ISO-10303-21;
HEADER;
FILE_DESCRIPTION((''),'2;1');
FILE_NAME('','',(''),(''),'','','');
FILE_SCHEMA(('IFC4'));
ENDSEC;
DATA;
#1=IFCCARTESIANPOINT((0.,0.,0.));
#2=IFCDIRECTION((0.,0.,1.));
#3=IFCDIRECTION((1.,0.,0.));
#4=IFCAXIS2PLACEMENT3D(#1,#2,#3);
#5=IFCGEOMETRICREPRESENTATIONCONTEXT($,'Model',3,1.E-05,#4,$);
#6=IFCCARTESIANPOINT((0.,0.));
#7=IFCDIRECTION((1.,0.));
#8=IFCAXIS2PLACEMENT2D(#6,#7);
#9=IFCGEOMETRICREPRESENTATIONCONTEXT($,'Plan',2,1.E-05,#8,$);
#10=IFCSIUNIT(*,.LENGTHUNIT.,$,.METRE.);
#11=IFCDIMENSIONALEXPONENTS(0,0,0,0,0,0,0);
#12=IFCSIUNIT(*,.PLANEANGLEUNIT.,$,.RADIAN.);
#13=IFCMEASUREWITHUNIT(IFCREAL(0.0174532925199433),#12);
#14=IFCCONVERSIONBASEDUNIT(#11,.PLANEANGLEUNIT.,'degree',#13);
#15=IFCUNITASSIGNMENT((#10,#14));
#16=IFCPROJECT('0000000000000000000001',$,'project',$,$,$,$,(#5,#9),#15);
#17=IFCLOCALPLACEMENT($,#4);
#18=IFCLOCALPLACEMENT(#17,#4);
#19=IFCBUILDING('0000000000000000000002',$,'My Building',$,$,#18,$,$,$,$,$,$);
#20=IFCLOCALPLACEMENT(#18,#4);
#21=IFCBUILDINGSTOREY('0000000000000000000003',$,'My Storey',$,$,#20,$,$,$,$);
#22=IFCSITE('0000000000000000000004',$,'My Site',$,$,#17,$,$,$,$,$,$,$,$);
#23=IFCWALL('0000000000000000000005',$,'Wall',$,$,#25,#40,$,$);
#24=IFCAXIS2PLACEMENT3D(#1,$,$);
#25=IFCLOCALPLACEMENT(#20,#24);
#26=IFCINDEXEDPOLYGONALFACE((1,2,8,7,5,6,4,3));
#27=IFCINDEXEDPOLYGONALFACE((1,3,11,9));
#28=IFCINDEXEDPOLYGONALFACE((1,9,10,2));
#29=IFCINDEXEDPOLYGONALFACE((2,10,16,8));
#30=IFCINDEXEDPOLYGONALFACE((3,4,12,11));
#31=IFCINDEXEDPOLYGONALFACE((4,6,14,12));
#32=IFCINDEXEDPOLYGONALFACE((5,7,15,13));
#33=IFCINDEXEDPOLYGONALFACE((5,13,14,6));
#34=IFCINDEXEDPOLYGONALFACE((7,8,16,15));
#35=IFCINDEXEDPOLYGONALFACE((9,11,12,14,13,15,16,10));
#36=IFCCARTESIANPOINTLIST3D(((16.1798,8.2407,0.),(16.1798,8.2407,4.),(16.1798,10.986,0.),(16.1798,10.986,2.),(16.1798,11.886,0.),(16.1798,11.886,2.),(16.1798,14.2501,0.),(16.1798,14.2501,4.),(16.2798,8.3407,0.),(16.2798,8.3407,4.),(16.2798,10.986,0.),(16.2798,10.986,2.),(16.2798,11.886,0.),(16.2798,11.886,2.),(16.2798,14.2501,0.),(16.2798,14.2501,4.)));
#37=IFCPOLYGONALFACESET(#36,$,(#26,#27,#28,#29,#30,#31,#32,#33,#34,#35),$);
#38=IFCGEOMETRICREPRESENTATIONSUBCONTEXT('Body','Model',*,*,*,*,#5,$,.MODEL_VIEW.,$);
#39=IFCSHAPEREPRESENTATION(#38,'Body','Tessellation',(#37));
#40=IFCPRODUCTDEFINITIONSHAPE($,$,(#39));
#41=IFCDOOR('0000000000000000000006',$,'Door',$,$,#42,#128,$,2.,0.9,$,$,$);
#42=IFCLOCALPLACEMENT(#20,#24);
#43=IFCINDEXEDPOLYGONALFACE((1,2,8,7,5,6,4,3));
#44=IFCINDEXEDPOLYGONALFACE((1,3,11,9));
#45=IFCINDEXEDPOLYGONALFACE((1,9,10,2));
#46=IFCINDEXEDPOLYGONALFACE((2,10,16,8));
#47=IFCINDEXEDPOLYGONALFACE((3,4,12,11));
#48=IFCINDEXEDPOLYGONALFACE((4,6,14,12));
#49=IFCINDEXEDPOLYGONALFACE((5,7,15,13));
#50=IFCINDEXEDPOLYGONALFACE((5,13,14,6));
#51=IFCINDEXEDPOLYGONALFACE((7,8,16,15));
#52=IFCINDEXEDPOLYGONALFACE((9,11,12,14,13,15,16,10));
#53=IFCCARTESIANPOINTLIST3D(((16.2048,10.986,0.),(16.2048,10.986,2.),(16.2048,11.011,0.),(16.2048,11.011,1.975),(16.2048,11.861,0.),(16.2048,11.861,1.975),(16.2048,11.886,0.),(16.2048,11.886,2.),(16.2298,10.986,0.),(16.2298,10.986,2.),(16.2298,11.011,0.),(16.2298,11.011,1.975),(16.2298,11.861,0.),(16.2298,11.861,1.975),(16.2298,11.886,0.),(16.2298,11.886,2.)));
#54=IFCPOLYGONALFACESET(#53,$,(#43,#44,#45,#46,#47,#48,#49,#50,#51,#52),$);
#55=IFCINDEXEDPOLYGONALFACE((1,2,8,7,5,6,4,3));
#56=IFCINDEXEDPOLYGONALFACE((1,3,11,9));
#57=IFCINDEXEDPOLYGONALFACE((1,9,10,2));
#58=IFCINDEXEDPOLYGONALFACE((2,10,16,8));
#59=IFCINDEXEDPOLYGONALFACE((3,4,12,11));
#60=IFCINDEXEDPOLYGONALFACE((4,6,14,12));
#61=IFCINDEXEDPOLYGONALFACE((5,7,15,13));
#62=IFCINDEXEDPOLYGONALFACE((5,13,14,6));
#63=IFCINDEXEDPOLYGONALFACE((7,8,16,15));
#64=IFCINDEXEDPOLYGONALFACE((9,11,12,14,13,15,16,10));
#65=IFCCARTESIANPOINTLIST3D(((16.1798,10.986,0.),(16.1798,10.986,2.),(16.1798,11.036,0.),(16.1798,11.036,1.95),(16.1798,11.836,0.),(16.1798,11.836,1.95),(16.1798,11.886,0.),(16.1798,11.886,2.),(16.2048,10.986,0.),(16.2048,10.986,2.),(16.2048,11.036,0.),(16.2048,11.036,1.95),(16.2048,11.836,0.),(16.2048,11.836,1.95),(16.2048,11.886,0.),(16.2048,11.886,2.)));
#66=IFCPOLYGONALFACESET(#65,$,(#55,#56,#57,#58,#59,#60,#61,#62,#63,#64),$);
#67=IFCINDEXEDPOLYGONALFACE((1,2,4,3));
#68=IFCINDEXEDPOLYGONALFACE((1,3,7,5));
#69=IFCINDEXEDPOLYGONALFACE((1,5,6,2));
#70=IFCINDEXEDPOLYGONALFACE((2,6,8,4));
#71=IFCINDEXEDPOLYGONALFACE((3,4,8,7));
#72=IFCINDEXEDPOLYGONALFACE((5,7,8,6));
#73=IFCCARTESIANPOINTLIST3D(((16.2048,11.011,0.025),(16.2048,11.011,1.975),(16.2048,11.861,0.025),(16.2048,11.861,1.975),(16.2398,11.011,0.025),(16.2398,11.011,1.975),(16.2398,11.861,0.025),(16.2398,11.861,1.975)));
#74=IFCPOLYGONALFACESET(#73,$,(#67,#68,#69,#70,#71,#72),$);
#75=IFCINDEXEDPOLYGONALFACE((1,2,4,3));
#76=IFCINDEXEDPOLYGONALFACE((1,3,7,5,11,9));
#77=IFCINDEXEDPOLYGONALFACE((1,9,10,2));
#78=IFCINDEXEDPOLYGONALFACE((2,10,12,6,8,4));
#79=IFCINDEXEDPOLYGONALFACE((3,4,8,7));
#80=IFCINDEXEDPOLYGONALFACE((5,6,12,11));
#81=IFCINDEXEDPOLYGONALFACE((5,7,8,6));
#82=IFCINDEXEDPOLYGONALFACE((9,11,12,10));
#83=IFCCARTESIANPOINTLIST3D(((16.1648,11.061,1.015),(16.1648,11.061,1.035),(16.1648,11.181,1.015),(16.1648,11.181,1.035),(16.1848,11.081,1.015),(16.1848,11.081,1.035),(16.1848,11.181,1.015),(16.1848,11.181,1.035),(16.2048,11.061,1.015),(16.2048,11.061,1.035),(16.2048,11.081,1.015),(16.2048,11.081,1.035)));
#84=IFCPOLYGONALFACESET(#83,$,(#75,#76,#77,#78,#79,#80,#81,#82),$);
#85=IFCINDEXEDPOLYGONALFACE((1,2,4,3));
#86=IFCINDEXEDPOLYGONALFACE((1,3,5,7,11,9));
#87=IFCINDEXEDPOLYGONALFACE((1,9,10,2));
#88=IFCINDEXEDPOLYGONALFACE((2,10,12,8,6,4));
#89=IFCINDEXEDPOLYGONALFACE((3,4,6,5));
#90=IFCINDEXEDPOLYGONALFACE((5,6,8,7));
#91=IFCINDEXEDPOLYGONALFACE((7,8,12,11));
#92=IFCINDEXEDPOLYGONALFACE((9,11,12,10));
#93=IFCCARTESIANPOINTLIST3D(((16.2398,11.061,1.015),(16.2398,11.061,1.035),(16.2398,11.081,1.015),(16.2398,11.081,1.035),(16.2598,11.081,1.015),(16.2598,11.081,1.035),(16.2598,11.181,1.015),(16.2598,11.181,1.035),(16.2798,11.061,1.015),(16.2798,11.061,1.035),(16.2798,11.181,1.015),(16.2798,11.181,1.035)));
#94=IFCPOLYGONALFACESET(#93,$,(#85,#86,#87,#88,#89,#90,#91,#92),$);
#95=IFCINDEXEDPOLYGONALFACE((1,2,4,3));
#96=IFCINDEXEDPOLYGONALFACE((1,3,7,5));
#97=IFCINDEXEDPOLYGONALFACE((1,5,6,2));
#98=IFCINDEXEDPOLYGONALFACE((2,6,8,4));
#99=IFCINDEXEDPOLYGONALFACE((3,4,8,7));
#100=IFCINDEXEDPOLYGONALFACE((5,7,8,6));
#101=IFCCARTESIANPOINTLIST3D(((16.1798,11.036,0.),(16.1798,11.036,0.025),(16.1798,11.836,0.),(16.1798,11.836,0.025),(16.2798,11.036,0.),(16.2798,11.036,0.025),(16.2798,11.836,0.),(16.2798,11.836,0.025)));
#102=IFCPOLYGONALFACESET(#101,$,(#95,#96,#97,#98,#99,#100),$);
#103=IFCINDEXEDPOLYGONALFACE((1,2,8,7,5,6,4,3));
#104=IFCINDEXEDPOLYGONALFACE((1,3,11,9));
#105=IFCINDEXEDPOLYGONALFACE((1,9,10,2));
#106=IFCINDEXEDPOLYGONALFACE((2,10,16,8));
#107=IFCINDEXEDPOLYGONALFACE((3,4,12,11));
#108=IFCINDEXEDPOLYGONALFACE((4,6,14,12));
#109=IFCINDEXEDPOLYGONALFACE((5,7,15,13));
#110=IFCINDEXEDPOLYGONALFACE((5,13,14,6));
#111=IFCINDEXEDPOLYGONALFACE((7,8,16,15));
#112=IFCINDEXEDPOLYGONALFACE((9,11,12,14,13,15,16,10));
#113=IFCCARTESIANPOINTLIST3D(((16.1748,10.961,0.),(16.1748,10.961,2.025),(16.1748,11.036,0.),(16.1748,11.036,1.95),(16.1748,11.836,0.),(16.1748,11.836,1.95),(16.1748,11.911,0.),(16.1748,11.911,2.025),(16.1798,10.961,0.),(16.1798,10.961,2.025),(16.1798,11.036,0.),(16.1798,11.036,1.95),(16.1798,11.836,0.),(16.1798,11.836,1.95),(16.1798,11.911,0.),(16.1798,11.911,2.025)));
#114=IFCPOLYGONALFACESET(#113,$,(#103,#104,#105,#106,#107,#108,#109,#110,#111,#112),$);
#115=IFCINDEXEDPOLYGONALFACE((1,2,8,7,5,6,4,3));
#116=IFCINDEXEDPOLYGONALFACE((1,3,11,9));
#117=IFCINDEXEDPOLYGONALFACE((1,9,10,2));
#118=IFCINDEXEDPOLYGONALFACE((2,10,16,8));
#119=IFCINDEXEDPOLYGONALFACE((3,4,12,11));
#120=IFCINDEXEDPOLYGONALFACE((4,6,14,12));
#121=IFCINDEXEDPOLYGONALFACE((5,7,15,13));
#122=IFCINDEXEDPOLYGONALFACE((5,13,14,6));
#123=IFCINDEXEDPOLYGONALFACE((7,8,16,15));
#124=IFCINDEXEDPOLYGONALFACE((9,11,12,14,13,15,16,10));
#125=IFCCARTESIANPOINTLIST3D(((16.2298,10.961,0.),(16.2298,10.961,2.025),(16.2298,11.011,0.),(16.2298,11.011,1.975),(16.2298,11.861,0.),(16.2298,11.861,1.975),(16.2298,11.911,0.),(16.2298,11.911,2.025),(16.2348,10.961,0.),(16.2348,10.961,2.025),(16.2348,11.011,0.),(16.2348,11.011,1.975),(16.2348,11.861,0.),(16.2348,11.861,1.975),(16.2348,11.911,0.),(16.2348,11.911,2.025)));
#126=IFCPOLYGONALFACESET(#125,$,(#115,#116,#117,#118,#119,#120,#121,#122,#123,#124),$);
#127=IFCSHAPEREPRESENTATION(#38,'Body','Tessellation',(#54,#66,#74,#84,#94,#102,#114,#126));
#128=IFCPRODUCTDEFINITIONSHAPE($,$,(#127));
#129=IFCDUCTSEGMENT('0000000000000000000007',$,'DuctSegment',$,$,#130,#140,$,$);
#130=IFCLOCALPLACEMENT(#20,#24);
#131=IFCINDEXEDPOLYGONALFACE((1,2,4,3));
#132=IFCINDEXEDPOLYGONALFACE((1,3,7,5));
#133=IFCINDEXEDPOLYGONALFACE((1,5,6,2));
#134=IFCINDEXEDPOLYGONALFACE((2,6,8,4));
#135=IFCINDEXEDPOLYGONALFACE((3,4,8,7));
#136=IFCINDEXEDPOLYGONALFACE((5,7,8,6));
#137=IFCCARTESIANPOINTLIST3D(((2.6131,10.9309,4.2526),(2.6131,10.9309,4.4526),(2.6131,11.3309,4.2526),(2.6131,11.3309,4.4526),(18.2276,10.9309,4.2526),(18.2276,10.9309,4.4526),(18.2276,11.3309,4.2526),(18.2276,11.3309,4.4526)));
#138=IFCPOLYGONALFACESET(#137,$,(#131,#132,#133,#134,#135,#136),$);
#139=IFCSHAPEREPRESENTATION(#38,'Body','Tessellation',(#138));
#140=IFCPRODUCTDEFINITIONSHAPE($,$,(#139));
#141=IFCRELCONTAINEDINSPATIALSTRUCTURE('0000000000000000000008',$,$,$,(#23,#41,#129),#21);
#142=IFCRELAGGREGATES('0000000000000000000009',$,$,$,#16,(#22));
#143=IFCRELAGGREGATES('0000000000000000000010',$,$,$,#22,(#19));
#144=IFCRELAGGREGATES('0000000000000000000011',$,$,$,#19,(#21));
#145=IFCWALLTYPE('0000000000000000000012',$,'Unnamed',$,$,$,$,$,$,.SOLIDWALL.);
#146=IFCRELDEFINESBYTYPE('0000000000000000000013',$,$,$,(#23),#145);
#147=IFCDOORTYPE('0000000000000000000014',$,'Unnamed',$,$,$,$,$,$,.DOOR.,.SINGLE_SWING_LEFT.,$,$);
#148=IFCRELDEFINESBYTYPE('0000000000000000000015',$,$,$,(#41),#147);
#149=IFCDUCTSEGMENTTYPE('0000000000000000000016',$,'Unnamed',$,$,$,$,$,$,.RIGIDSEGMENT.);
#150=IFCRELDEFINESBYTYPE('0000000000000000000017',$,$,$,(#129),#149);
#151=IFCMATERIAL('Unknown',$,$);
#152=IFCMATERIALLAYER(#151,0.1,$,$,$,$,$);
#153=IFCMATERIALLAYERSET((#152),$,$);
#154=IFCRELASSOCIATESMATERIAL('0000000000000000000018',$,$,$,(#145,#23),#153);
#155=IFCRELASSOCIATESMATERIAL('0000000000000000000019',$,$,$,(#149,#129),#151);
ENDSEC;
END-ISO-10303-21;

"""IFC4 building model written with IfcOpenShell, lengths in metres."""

from ifc_helpers import new_model, entity, si_unit, converted_unit, frame, origin_with_axes, origin_2d_with_axis, place, context, subcontext, project, spatial, line, indexed_curve, rectangle, outline, extrude, shape, source, transform, mapped, material, layer, layer_set, layer_usage, material_profile, profile_set, profile_usage, type_object, type_shapes, element, fill, save


model = new_model("IFC4")

# Units and contexts
model_context = context("Model", 3, precision=1e-05, world=origin_with_axes())
plan_context = context("Plan", 2, precision=1e-05, world=origin_2d_with_axis())
body_context_1 = subcontext(model_context, "Body", "Model", "MODEL_VIEW")
body_context_2 = subcontext(plan_context, "Body", "Plan", "PLAN_VIEW")
ifc_project = project(units=[si_unit("LENGTHUNIT", "METRE"), converted_unit("PLANEANGLEUNIT", "degree", entity("IfcReal", 0.0174532925199433), si_unit("PLANEANGLEUNIT", "RADIAN"), dimensions=[0, 0, 0, 0, 0, 0, 0])], contexts=[model_context, plan_context])

# Site, building, storey
site_placement = place(None, origin_with_axes())
site = spatial("IfcSite", under=ifc_project, at=site_placement, Name="My Site")
building_placement = place(site_placement, origin_with_axes())
building = spatial("IfcBuilding", under=site, at=building_placement, Name="My Building")
storey_placement = place(building_placement, origin_with_axes())
storey = spatial("IfcBuildingStorey", under=building, at=storey_placement, Name="My Storey")

# Shared definitions
ifc_material = material(Name="Unknown")

# Shared definitions
ifc_layer_1 = layer(ifc_material, 0.1)
ifc_layer_set_1 = layer_set([ifc_layer_1])
wall_type = type_object("IfcWallType", Name="Unnamed", PredefinedType="SOLIDWALL", material=ifc_layer_set_1)

# Wall, opening, door
shared_shape_1 = source(origin_with_axes(), body_context_1, "Body", "SweptSolid", [
    extrude(outline(indexed_curve([(0.0, 0.0), (0.9, 0.0), (0.9, 2.0), (0.0, 2.0)], segments=[line(1, 2, 3, 4, 1)])), frame((0.0, -0.6, 0.0), z_axis=(0.0, -1.0, 0.0), x_axis=(1.0, 0.0, 0.0)), (0.0, 0.0, -1.0), 1.2),
])
door_type = type_object("IfcDoorType", Name="Unnamed", OperationType="SINGLE_SWING_LEFT", PredefinedType="DOOR")
shared_shape_2 = source(origin_with_axes(), body_context_1, "Body", "SweptSolid", [
    extrude(outline(indexed_curve([(0.0, 0.0), (0.0, 2.0), (0.9, 2.0), (0.9, 0.0), (0.875, 0.0), (0.875, 1.975), (0.025, 1.975), (0.025, 0.0)], segments=[line(1, 2, 3, 4, 5, 6, 7, 8, 1)])), frame((0.0, 0.025, 0.0), z_axis=(0.0, -1.0, 0.0), x_axis=(1.0, 0.0, 0.0)), (0.0, 0.0, -1.0), 0.025),
    extrude(outline(indexed_curve([(0.0, 0.0), (0.0, 2.0), (0.9, 2.0), (0.9, 0.0), (0.85, 0.0), (0.85, 1.95), (0.05, 1.95), (0.05, 0.0)], segments=[line(1, 2, 3, 4, 5, 6, 7, 8, 1)])), frame((0.0, 0.0, 0.0), z_axis=(0.0, -1.0, 0.0), x_axis=(1.0, 0.0, 0.0)), (0.0, 0.0, -1.0), 0.025),
    extrude(outline(indexed_curve([(0.0, 0.0), (0.85, 0.0), (0.85, 0.035), (0.0, 0.035)], segments=[line(1, 2, 3, 4, 1)])), frame((0.025, 0.025, 0.025), z_axis=(0.0, 0.0, 1.0), x_axis=(1.0, 0.0, 0.0)), (0.0, 0.0, 1.0), 1.95),
    extrude(outline(indexed_curve([(0.0, 0.0), (0.0, -0.04), (-0.12, -0.04), (-0.12, -0.02), (-0.02, -0.02), (-0.02, 0.0)], segments=[line(1, 2, 3, 4, 5, 6, 1)])), frame((0.825, 0.025, 1.015), z_axis=(0.0, 0.0, 1.0), x_axis=(1.0, 0.0, 0.0)), (0.0, 0.0, 1.0), 0.02),
    extrude(outline(indexed_curve([(0.0, 0.0), (0.0, 0.04), (-0.12, 0.04), (-0.12, 0.02), (-0.02, 0.02), (-0.02, 0.0)], segments=[line(1, 2, 3, 4, 5, 6, 1)])), frame((0.825, 0.06, 1.015), z_axis=(0.0, 0.0, 1.0), x_axis=(1.0, 0.0, 0.0)), (0.0, 0.0, 1.0), 0.02),
    extrude(outline(indexed_curve([(0.0, 0.0), (0.8, 0.0), (0.8, 0.1), (0.0, 0.1)], segments=[line(1, 2, 3, 4, 1)])), frame((0.05, 0.0, 0.0), z_axis=(0.0, 0.0, 1.0), x_axis=(1.0, 0.0, 0.0)), (0.0, 0.0, 1.0), 0.025),
    extrude(outline(indexed_curve([(0.0, 0.0), (0.0, 2.025), (0.95, 2.025), (0.95, 0.0), (0.875, 0.0), (0.875, 1.95), (0.075, 1.95), (0.075, 0.0)], segments=[line(1, 2, 3, 4, 5, 6, 7, 8, 1)])), frame((-0.025, -0.005, 0.0), z_axis=(0.0, -1.0, 0.0), x_axis=(1.0, 0.0, 0.0)), (0.0, 0.0, -1.0), 0.005),
    extrude(outline(indexed_curve([(0.0, 0.0), (0.0, 2.025), (0.95, 2.025), (0.95, 0.0), (0.9, 0.0), (0.9, 1.975), (0.05, 1.975), (0.05, 0.0)], segments=[line(1, 2, 3, 4, 5, 6, 7, 8, 1)])), frame((-0.025, 0.05, 0.0), z_axis=(0.0, -1.0, 0.0), x_axis=(1.0, 0.0, 0.0)), (0.0, 0.0, -1.0), 0.005),
])
shared_shape_3 = source(origin_with_axes(), body_context_2, "Body", "Curve2D", [
    entity("IfcIndexedPolyCurve", entity("IfcCartesianPointList2D", [[0.0, 0.0], [0.0, 0.05], [0.025, 0.05], [0.025, 0.025], [0.05, 0.025], [0.05, 0.0]]), [entity("IfcLineIndex", [1, 2, 3, 4, 5, 6, 1])]),
    entity("IfcIndexedPolyCurve", entity("IfcCartesianPointList2D", [[0.9, 0.0], [0.9, 0.05], [0.875, 0.05], [0.875, 0.025], [0.85, 0.025], [0.85, 0.0]]), [entity("IfcLineIndex", [1, 2, 3, 4, 5, 6, 1])]),
    entity("IfcTrimmedCurve", entity("IfcEllipse", entity("IfcAxis2Placement2D", entity("IfcCartesianPoint", [0.06, 0.05]), entity("IfcDirection", [1.0, 0.0])), 0.815, 0.85), [entity("IfcCartesianPoint", [0.875, 0.05])], [entity("IfcCartesianPoint", [0.06, 0.9])], True, "CARTESIAN"),
    entity("IfcIndexedPolyCurve", entity("IfcCartesianPointList2D", [[0.025, 0.05], [0.06, 0.05], [0.06, 0.9], [0.025, 0.9]]), [entity("IfcLineIndex", [1, 2, 3, 4, 1])]),
])
type_shapes(door_type, [shared_shape_2, shared_shape_3])
ifc_layer_usage_1 = layer_usage(ifc_layer_set_1, "AXIS2", "POSITIVE", 0.0)
wall_1_placement = place(storey_placement, frame((16.1798, 14.2501, 0.0), z_axis=(0.0, 0.0, 1.0), x_axis=(0.0, -1.0, 0.0)))
wall_1 = element("IfcWall", 1, at=wall_1_placement, inside=storey, type_object=wall_type, material=ifc_layer_usage_1, Name="Wall", context=body_context_1, shape_type="SweptSolid", body=[
    extrude(outline(indexed_curve([(0.0, 0.0), (0.0, 0.1), (5.9093, 0.1), (6.0093, 0.0)], segments=[line(1, 2, 3, 4, 1)])), origin_with_axes(), (0.0, 0.0, 1.0), 4.0),
])
opening_1_placement = place(wall_1_placement, frame((2.364, 0.0, 0.0), z_axis=(0.0, 0.0, 1.0), x_axis=(1.0, 0.0, 0.0)))
opening_1 = element("IfcOpeningElement", 2, at=opening_1_placement, cuts=wall_1, PredefinedType="OPENING", context=body_context_1, shape_type="MappedRepresentation", body=[
    mapped(shared_shape_1, transform((0.0, 0.0, 0.0), x_axis=(1.0, 0.0, 0.0), y_axis=(0.0, 1.0, 0.0), z_axis=(0.0, 0.0, 1.0), scale=1.0)),
])
door_1_placement = place(opening_1_placement, frame((0.0, 0.0, 0.0), z_axis=(0.0, 0.0, 1.0), x_axis=(1.0, 0.0, 0.0)))
door_1 = element("IfcDoor", 3, at=door_1_placement, inside=storey, type_object=door_type, Name="Door", OverallHeight=2.0, OverallWidth=0.9, shapes=[
    shape(body_context_1, "Body", "MappedRepresentation", [mapped(shared_shape_2, transform((0.0, 0.0, 0.0), x_axis=(1.0, 0.0, 0.0), y_axis=(0.0, 1.0, 0.0), z_axis=(0.0, 0.0, 1.0), scale=1.0))]),
    shape(body_context_2, "Body", "MappedRepresentation", [mapped(shared_shape_3, transform((0.0, 0.0, 0.0), x_axis=(1.0, 0.0, 0.0), y_axis=(0.0, 1.0, 0.0), z_axis=(0.0, 0.0, 1.0), scale=1.0))]),
])
fill(opening_1, door_1)

# Duct segment
ifc_material_profile_1 = material_profile(ifc_material, rectangle(XDim=0.4, YDim=0.2))
ifc_profile_set_1 = profile_set([ifc_material_profile_1])
ifc_profile_usage_1 = profile_usage(ifc_profile_set_1, cardinal=5)
duct_segment_type = type_object("IfcDuctSegmentType", Name="Unnamed", PredefinedType="RIGIDSEGMENT", material=ifc_profile_set_1)
duct_segment_placement = place(storey_placement, frame((18.2276, 11.1309, 4.3526), z_axis=(-1.0, 0.0, 0.0), x_axis=(0.0, -1.0, 0.0)))
element("IfcDuctSegment", 4, at=duct_segment_placement, inside=storey, type_object=duct_segment_type, material=ifc_profile_usage_1, Name="DuctSegment", context=body_context_1, shape_type="SweptSolid", body=[
    extrude(rectangle(XDim=0.4, YDim=0.2), origin_with_axes(), (0.0, 0.0, 1.0), 15.6145),
])

save(model, "model.ifc")
